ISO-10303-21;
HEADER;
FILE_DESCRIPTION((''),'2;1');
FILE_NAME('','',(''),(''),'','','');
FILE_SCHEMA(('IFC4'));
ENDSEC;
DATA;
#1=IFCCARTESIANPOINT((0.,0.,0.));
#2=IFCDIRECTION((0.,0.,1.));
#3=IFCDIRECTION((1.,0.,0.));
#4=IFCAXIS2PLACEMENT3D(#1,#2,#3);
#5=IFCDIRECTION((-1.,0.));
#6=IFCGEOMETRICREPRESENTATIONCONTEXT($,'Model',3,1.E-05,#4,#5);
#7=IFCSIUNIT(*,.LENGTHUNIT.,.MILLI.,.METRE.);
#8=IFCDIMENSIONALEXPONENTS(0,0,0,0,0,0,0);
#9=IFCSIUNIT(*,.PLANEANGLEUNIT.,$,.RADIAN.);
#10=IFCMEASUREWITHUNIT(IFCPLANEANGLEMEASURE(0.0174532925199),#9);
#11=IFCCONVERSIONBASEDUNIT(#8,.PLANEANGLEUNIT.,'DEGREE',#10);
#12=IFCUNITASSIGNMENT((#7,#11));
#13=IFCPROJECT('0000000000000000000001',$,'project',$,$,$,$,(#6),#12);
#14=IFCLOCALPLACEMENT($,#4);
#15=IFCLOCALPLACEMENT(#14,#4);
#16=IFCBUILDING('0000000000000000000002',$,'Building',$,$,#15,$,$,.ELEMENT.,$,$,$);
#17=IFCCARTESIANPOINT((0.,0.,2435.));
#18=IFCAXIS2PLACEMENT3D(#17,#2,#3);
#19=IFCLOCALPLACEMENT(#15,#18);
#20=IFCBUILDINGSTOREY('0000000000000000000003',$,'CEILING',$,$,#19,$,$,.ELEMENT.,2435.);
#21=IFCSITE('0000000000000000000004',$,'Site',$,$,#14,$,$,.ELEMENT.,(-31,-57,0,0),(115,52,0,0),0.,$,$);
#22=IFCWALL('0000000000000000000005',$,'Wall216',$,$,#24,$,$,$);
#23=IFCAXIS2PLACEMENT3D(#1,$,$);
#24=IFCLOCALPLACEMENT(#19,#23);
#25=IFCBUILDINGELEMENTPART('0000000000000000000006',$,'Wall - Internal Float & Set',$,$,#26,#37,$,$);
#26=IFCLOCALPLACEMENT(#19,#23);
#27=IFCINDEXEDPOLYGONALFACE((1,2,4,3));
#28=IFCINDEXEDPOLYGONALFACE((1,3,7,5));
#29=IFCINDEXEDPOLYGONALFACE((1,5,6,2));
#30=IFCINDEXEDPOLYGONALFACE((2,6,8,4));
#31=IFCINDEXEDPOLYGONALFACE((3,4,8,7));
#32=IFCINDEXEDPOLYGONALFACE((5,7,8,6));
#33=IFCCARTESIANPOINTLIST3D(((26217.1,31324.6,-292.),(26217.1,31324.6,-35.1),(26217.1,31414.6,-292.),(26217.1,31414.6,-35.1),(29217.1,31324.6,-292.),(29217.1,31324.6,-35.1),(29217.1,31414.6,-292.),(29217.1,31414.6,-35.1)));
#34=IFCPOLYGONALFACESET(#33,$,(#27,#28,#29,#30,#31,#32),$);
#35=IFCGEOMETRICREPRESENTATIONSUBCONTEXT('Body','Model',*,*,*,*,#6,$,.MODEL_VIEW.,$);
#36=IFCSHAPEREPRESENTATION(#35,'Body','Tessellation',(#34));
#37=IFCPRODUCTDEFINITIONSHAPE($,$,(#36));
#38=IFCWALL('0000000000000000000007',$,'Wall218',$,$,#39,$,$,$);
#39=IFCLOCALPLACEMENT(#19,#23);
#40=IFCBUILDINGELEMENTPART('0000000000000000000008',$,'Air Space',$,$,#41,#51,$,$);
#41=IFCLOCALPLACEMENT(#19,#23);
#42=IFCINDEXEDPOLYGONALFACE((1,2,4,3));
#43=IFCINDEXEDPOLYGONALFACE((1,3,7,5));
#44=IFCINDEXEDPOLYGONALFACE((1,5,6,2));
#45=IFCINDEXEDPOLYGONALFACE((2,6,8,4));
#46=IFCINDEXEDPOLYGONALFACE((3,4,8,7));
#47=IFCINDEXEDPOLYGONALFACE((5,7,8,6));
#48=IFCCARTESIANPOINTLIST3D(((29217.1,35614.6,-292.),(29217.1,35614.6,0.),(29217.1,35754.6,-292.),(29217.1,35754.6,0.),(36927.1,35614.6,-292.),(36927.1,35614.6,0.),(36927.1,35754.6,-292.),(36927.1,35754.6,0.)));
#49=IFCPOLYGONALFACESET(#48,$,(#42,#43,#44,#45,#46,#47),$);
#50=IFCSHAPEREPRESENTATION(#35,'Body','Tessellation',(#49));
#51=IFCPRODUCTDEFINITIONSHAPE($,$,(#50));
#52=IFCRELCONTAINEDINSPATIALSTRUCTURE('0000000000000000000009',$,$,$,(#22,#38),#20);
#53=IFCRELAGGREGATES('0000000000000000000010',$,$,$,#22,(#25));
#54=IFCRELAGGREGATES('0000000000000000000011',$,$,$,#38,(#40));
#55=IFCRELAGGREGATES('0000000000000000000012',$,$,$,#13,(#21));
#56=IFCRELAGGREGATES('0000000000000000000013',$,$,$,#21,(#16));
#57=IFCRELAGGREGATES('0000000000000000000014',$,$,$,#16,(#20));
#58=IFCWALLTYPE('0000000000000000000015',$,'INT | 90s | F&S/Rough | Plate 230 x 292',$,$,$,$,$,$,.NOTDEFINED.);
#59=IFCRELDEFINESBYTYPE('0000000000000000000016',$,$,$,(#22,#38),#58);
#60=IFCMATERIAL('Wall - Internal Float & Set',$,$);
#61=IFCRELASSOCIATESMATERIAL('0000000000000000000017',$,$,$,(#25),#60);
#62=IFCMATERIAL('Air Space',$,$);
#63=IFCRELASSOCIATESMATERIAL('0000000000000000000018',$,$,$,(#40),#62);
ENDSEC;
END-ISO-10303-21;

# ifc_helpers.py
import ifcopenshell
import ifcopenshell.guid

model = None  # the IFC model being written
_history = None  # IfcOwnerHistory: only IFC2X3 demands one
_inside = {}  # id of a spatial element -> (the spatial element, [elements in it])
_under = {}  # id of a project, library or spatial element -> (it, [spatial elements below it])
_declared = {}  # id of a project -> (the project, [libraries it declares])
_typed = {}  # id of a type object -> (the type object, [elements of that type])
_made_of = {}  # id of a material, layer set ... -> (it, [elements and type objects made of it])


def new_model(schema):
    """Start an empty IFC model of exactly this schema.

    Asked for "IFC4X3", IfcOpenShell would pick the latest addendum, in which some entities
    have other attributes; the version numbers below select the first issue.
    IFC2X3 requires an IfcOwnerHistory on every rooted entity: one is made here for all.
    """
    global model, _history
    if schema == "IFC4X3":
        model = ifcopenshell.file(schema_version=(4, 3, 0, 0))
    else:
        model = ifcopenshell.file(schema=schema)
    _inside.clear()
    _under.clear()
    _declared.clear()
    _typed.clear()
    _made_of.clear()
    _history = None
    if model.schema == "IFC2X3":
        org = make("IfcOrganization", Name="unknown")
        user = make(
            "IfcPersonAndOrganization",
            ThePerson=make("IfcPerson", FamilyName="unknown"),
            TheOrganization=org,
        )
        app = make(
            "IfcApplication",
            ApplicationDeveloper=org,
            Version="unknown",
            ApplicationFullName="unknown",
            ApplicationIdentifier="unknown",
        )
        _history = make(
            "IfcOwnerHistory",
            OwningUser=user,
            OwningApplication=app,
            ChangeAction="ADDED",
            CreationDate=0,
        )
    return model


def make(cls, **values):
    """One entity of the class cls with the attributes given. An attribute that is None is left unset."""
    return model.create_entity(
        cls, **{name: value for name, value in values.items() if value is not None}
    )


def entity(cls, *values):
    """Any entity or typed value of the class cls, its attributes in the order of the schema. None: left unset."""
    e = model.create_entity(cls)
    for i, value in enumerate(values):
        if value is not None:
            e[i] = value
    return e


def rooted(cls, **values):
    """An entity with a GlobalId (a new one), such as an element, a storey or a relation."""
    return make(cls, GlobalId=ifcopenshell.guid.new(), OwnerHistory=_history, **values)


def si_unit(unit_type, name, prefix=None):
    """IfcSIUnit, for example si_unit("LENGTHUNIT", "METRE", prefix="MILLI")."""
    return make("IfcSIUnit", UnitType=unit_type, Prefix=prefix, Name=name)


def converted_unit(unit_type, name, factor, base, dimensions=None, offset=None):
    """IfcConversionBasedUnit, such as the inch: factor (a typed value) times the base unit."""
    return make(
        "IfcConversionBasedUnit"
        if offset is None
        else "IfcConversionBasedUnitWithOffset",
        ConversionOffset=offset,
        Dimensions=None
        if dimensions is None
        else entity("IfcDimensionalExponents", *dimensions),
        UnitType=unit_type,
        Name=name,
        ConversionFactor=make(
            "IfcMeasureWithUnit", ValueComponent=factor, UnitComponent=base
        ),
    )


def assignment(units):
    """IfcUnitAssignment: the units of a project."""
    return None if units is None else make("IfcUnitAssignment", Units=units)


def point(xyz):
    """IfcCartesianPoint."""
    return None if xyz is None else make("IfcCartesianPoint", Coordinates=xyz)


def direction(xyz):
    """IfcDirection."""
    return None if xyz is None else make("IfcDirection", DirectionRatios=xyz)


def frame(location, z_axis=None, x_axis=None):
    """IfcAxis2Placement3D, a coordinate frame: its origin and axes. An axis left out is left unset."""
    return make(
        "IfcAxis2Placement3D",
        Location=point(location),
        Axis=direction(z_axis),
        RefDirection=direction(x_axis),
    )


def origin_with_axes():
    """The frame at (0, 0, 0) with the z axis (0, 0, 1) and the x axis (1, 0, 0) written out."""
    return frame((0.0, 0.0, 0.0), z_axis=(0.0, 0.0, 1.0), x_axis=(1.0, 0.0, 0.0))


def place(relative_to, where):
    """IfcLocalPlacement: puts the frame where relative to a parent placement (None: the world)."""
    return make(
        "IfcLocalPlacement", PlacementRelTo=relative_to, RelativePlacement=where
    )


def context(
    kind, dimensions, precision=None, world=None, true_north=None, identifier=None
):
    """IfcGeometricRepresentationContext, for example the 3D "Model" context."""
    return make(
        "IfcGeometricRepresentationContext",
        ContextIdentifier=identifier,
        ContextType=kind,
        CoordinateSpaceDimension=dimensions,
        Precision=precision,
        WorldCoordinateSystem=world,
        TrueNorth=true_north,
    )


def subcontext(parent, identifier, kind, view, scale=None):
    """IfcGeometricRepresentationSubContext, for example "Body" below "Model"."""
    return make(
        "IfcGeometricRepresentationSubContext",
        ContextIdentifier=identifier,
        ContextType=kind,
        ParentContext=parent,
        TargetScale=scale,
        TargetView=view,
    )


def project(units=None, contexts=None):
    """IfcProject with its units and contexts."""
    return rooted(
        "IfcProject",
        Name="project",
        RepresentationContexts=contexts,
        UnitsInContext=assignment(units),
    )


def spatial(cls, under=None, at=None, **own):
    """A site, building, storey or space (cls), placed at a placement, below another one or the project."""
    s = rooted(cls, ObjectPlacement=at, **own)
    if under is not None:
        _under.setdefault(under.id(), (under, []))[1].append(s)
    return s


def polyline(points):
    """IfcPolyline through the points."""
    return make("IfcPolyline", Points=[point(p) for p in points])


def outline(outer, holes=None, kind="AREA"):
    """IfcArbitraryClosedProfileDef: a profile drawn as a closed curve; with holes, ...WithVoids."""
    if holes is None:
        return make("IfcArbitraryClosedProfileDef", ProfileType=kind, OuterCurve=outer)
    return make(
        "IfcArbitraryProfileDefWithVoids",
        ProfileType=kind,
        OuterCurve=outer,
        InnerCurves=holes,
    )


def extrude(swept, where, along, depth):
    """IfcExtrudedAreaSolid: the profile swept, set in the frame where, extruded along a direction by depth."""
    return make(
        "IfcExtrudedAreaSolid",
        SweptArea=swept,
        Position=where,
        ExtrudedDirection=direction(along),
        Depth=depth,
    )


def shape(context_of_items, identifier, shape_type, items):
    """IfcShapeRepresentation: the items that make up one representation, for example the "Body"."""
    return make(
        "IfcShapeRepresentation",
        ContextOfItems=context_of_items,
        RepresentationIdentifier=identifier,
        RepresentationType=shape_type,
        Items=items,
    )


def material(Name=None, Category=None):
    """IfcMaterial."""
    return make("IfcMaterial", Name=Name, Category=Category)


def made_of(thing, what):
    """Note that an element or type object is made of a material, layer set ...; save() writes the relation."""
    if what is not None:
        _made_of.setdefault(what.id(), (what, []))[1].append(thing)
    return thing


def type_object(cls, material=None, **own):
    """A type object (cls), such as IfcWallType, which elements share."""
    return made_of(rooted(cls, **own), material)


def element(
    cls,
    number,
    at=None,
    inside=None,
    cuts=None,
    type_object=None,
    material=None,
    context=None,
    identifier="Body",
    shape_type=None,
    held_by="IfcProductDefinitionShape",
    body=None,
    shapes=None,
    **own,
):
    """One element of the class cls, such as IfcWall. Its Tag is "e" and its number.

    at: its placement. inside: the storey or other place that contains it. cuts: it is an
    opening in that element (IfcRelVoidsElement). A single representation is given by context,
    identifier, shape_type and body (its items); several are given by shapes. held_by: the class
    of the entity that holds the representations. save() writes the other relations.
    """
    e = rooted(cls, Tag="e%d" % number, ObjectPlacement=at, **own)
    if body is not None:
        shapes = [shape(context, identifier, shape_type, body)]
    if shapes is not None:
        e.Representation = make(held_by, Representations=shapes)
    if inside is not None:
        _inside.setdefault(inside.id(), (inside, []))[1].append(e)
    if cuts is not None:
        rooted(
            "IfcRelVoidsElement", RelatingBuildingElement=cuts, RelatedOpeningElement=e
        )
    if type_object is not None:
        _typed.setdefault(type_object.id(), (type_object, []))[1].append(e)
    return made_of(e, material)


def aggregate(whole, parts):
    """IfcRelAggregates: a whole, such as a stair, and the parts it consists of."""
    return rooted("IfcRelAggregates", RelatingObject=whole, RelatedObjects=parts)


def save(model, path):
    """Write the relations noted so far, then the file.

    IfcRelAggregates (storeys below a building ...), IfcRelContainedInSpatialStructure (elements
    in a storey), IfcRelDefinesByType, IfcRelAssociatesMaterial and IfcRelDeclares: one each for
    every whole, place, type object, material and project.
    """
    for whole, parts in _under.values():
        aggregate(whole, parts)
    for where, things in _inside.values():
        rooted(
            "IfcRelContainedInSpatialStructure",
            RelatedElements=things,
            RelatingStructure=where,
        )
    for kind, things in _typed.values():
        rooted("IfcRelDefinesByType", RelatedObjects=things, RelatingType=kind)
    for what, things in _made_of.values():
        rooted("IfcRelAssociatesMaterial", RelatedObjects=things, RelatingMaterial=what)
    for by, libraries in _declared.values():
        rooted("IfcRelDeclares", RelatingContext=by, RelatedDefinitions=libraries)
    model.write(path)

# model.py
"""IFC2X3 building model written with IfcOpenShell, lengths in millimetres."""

from ifc_helpers import new_model, entity, si_unit, converted_unit, direction, frame, origin_with_axes, place, context, subcontext, project, spatial, polyline, outline, extrude, material, type_object, element, aggregate, save


model = new_model("IFC2X3")

# Units and contexts
model_context = context("Model", 3, precision=1e-05, world=origin_with_axes(), true_north=direction((-1.0, 0.0)))
body_context = subcontext(model_context, "Body", "Model", "MODEL_VIEW")
ifc_project = project(units=[si_unit("LENGTHUNIT", "METRE", prefix="MILLI"), converted_unit("PLANEANGLEUNIT", "DEGREE", entity("IfcPlaneAngleMeasure", 0.0174532925199), si_unit("PLANEANGLEUNIT", "RADIAN"), dimensions=[0, 0, 0, 0, 0, 0, 0])], contexts=[model_context])

# Site, building, storey
site_placement = place(None, origin_with_axes())
site = spatial("IfcSite", under=ifc_project, at=site_placement, Name="Site", CompositionType="ELEMENT", RefLatitude=(-31, -57, 0, 0), RefLongitude=(115, 52, 0, 0), RefElevation=0.0)
building_placement = place(site_placement, origin_with_axes())
building = spatial("IfcBuilding", under=site, at=building_placement, Name="Building", CompositionType="ELEMENT")
storey_placement = place(building_placement, frame((0.0, 0.0, 2435.0), z_axis=(0.0, 0.0, 1.0), x_axis=(1.0, 0.0, 0.0)))
storey = spatial("IfcBuildingStorey", under=building, at=storey_placement, Name="CEILING", CompositionType="ELEMENT", Elevation=2435.0)

# Walls, building element parts
wall_type = type_object("IfcWallType", Name="INT | 90s | F&S/Rough | Plate 230 x 292", PredefinedType="NOTDEFINED")
ifc_material_1 = material(Name="Air Space")
ifc_material_2 = material(Name="Wall - Internal Float & Set")
wall_1_placement = place(storey_placement, frame((26217.1, 31414.6, -292.0), z_axis=(0.0, 0.0, 1.0), x_axis=(1.0, 0.0, 0.0)))
wall_1 = element("IfcWall", 1, at=wall_1_placement, inside=storey, type_object=wall_type, Name="Wall216")
building_element_part_1_placement = place(wall_1_placement, origin_with_axes())
building_element_part_1 = element("IfcBuildingElementPart", 2, at=building_element_part_1_placement, material=ifc_material_2, Name="Wall - Internal Float & Set", context=body_context, shape_type="SweptSolid", body=[
    extrude(outline(polyline([(-90.0, 256.9), (-90.0, 0.0), (0.0, 0.0), (0.0, 256.9), (-90.0, 256.9)])), frame((0.0, 0.0, 0.0), z_axis=(1.0, 0.0, 0.0), x_axis=(0.0, 1.0, 0.0)), (0.0, 0.0, 1.0), 3000.0),
])
aggregate(wall_1, [building_element_part_1])
wall_2_placement = place(storey_placement, frame((29217.1, 35614.6, -292.0), z_axis=(0.0, 0.0, 1.0), x_axis=(1.0, 0.0, 0.0)))
wall_2 = element("IfcWall", 3, at=wall_2_placement, inside=storey, type_object=wall_type, Name="Wall218")
building_element_part_2_placement = place(wall_2_placement, origin_with_axes())
building_element_part_2 = element("IfcBuildingElementPart", 4, at=building_element_part_2_placement, material=ifc_material_1, Name="Air Space", context=body_context, shape_type="SweptSolid", body=[
    extrude(outline(polyline([(0.0, 292.0), (0.0, 0.0), (140.0, 0.0), (140.0, 292.0), (0.0, 292.0)])), frame((0.0, 0.0, 0.0), z_axis=(1.0, 0.0, 0.0), x_axis=(0.0, 1.0, 0.0)), (0.0, 0.0, 1.0), 7710.0),
])
aggregate(wall_2, [building_element_part_2])

save(model, "model.ifc")
